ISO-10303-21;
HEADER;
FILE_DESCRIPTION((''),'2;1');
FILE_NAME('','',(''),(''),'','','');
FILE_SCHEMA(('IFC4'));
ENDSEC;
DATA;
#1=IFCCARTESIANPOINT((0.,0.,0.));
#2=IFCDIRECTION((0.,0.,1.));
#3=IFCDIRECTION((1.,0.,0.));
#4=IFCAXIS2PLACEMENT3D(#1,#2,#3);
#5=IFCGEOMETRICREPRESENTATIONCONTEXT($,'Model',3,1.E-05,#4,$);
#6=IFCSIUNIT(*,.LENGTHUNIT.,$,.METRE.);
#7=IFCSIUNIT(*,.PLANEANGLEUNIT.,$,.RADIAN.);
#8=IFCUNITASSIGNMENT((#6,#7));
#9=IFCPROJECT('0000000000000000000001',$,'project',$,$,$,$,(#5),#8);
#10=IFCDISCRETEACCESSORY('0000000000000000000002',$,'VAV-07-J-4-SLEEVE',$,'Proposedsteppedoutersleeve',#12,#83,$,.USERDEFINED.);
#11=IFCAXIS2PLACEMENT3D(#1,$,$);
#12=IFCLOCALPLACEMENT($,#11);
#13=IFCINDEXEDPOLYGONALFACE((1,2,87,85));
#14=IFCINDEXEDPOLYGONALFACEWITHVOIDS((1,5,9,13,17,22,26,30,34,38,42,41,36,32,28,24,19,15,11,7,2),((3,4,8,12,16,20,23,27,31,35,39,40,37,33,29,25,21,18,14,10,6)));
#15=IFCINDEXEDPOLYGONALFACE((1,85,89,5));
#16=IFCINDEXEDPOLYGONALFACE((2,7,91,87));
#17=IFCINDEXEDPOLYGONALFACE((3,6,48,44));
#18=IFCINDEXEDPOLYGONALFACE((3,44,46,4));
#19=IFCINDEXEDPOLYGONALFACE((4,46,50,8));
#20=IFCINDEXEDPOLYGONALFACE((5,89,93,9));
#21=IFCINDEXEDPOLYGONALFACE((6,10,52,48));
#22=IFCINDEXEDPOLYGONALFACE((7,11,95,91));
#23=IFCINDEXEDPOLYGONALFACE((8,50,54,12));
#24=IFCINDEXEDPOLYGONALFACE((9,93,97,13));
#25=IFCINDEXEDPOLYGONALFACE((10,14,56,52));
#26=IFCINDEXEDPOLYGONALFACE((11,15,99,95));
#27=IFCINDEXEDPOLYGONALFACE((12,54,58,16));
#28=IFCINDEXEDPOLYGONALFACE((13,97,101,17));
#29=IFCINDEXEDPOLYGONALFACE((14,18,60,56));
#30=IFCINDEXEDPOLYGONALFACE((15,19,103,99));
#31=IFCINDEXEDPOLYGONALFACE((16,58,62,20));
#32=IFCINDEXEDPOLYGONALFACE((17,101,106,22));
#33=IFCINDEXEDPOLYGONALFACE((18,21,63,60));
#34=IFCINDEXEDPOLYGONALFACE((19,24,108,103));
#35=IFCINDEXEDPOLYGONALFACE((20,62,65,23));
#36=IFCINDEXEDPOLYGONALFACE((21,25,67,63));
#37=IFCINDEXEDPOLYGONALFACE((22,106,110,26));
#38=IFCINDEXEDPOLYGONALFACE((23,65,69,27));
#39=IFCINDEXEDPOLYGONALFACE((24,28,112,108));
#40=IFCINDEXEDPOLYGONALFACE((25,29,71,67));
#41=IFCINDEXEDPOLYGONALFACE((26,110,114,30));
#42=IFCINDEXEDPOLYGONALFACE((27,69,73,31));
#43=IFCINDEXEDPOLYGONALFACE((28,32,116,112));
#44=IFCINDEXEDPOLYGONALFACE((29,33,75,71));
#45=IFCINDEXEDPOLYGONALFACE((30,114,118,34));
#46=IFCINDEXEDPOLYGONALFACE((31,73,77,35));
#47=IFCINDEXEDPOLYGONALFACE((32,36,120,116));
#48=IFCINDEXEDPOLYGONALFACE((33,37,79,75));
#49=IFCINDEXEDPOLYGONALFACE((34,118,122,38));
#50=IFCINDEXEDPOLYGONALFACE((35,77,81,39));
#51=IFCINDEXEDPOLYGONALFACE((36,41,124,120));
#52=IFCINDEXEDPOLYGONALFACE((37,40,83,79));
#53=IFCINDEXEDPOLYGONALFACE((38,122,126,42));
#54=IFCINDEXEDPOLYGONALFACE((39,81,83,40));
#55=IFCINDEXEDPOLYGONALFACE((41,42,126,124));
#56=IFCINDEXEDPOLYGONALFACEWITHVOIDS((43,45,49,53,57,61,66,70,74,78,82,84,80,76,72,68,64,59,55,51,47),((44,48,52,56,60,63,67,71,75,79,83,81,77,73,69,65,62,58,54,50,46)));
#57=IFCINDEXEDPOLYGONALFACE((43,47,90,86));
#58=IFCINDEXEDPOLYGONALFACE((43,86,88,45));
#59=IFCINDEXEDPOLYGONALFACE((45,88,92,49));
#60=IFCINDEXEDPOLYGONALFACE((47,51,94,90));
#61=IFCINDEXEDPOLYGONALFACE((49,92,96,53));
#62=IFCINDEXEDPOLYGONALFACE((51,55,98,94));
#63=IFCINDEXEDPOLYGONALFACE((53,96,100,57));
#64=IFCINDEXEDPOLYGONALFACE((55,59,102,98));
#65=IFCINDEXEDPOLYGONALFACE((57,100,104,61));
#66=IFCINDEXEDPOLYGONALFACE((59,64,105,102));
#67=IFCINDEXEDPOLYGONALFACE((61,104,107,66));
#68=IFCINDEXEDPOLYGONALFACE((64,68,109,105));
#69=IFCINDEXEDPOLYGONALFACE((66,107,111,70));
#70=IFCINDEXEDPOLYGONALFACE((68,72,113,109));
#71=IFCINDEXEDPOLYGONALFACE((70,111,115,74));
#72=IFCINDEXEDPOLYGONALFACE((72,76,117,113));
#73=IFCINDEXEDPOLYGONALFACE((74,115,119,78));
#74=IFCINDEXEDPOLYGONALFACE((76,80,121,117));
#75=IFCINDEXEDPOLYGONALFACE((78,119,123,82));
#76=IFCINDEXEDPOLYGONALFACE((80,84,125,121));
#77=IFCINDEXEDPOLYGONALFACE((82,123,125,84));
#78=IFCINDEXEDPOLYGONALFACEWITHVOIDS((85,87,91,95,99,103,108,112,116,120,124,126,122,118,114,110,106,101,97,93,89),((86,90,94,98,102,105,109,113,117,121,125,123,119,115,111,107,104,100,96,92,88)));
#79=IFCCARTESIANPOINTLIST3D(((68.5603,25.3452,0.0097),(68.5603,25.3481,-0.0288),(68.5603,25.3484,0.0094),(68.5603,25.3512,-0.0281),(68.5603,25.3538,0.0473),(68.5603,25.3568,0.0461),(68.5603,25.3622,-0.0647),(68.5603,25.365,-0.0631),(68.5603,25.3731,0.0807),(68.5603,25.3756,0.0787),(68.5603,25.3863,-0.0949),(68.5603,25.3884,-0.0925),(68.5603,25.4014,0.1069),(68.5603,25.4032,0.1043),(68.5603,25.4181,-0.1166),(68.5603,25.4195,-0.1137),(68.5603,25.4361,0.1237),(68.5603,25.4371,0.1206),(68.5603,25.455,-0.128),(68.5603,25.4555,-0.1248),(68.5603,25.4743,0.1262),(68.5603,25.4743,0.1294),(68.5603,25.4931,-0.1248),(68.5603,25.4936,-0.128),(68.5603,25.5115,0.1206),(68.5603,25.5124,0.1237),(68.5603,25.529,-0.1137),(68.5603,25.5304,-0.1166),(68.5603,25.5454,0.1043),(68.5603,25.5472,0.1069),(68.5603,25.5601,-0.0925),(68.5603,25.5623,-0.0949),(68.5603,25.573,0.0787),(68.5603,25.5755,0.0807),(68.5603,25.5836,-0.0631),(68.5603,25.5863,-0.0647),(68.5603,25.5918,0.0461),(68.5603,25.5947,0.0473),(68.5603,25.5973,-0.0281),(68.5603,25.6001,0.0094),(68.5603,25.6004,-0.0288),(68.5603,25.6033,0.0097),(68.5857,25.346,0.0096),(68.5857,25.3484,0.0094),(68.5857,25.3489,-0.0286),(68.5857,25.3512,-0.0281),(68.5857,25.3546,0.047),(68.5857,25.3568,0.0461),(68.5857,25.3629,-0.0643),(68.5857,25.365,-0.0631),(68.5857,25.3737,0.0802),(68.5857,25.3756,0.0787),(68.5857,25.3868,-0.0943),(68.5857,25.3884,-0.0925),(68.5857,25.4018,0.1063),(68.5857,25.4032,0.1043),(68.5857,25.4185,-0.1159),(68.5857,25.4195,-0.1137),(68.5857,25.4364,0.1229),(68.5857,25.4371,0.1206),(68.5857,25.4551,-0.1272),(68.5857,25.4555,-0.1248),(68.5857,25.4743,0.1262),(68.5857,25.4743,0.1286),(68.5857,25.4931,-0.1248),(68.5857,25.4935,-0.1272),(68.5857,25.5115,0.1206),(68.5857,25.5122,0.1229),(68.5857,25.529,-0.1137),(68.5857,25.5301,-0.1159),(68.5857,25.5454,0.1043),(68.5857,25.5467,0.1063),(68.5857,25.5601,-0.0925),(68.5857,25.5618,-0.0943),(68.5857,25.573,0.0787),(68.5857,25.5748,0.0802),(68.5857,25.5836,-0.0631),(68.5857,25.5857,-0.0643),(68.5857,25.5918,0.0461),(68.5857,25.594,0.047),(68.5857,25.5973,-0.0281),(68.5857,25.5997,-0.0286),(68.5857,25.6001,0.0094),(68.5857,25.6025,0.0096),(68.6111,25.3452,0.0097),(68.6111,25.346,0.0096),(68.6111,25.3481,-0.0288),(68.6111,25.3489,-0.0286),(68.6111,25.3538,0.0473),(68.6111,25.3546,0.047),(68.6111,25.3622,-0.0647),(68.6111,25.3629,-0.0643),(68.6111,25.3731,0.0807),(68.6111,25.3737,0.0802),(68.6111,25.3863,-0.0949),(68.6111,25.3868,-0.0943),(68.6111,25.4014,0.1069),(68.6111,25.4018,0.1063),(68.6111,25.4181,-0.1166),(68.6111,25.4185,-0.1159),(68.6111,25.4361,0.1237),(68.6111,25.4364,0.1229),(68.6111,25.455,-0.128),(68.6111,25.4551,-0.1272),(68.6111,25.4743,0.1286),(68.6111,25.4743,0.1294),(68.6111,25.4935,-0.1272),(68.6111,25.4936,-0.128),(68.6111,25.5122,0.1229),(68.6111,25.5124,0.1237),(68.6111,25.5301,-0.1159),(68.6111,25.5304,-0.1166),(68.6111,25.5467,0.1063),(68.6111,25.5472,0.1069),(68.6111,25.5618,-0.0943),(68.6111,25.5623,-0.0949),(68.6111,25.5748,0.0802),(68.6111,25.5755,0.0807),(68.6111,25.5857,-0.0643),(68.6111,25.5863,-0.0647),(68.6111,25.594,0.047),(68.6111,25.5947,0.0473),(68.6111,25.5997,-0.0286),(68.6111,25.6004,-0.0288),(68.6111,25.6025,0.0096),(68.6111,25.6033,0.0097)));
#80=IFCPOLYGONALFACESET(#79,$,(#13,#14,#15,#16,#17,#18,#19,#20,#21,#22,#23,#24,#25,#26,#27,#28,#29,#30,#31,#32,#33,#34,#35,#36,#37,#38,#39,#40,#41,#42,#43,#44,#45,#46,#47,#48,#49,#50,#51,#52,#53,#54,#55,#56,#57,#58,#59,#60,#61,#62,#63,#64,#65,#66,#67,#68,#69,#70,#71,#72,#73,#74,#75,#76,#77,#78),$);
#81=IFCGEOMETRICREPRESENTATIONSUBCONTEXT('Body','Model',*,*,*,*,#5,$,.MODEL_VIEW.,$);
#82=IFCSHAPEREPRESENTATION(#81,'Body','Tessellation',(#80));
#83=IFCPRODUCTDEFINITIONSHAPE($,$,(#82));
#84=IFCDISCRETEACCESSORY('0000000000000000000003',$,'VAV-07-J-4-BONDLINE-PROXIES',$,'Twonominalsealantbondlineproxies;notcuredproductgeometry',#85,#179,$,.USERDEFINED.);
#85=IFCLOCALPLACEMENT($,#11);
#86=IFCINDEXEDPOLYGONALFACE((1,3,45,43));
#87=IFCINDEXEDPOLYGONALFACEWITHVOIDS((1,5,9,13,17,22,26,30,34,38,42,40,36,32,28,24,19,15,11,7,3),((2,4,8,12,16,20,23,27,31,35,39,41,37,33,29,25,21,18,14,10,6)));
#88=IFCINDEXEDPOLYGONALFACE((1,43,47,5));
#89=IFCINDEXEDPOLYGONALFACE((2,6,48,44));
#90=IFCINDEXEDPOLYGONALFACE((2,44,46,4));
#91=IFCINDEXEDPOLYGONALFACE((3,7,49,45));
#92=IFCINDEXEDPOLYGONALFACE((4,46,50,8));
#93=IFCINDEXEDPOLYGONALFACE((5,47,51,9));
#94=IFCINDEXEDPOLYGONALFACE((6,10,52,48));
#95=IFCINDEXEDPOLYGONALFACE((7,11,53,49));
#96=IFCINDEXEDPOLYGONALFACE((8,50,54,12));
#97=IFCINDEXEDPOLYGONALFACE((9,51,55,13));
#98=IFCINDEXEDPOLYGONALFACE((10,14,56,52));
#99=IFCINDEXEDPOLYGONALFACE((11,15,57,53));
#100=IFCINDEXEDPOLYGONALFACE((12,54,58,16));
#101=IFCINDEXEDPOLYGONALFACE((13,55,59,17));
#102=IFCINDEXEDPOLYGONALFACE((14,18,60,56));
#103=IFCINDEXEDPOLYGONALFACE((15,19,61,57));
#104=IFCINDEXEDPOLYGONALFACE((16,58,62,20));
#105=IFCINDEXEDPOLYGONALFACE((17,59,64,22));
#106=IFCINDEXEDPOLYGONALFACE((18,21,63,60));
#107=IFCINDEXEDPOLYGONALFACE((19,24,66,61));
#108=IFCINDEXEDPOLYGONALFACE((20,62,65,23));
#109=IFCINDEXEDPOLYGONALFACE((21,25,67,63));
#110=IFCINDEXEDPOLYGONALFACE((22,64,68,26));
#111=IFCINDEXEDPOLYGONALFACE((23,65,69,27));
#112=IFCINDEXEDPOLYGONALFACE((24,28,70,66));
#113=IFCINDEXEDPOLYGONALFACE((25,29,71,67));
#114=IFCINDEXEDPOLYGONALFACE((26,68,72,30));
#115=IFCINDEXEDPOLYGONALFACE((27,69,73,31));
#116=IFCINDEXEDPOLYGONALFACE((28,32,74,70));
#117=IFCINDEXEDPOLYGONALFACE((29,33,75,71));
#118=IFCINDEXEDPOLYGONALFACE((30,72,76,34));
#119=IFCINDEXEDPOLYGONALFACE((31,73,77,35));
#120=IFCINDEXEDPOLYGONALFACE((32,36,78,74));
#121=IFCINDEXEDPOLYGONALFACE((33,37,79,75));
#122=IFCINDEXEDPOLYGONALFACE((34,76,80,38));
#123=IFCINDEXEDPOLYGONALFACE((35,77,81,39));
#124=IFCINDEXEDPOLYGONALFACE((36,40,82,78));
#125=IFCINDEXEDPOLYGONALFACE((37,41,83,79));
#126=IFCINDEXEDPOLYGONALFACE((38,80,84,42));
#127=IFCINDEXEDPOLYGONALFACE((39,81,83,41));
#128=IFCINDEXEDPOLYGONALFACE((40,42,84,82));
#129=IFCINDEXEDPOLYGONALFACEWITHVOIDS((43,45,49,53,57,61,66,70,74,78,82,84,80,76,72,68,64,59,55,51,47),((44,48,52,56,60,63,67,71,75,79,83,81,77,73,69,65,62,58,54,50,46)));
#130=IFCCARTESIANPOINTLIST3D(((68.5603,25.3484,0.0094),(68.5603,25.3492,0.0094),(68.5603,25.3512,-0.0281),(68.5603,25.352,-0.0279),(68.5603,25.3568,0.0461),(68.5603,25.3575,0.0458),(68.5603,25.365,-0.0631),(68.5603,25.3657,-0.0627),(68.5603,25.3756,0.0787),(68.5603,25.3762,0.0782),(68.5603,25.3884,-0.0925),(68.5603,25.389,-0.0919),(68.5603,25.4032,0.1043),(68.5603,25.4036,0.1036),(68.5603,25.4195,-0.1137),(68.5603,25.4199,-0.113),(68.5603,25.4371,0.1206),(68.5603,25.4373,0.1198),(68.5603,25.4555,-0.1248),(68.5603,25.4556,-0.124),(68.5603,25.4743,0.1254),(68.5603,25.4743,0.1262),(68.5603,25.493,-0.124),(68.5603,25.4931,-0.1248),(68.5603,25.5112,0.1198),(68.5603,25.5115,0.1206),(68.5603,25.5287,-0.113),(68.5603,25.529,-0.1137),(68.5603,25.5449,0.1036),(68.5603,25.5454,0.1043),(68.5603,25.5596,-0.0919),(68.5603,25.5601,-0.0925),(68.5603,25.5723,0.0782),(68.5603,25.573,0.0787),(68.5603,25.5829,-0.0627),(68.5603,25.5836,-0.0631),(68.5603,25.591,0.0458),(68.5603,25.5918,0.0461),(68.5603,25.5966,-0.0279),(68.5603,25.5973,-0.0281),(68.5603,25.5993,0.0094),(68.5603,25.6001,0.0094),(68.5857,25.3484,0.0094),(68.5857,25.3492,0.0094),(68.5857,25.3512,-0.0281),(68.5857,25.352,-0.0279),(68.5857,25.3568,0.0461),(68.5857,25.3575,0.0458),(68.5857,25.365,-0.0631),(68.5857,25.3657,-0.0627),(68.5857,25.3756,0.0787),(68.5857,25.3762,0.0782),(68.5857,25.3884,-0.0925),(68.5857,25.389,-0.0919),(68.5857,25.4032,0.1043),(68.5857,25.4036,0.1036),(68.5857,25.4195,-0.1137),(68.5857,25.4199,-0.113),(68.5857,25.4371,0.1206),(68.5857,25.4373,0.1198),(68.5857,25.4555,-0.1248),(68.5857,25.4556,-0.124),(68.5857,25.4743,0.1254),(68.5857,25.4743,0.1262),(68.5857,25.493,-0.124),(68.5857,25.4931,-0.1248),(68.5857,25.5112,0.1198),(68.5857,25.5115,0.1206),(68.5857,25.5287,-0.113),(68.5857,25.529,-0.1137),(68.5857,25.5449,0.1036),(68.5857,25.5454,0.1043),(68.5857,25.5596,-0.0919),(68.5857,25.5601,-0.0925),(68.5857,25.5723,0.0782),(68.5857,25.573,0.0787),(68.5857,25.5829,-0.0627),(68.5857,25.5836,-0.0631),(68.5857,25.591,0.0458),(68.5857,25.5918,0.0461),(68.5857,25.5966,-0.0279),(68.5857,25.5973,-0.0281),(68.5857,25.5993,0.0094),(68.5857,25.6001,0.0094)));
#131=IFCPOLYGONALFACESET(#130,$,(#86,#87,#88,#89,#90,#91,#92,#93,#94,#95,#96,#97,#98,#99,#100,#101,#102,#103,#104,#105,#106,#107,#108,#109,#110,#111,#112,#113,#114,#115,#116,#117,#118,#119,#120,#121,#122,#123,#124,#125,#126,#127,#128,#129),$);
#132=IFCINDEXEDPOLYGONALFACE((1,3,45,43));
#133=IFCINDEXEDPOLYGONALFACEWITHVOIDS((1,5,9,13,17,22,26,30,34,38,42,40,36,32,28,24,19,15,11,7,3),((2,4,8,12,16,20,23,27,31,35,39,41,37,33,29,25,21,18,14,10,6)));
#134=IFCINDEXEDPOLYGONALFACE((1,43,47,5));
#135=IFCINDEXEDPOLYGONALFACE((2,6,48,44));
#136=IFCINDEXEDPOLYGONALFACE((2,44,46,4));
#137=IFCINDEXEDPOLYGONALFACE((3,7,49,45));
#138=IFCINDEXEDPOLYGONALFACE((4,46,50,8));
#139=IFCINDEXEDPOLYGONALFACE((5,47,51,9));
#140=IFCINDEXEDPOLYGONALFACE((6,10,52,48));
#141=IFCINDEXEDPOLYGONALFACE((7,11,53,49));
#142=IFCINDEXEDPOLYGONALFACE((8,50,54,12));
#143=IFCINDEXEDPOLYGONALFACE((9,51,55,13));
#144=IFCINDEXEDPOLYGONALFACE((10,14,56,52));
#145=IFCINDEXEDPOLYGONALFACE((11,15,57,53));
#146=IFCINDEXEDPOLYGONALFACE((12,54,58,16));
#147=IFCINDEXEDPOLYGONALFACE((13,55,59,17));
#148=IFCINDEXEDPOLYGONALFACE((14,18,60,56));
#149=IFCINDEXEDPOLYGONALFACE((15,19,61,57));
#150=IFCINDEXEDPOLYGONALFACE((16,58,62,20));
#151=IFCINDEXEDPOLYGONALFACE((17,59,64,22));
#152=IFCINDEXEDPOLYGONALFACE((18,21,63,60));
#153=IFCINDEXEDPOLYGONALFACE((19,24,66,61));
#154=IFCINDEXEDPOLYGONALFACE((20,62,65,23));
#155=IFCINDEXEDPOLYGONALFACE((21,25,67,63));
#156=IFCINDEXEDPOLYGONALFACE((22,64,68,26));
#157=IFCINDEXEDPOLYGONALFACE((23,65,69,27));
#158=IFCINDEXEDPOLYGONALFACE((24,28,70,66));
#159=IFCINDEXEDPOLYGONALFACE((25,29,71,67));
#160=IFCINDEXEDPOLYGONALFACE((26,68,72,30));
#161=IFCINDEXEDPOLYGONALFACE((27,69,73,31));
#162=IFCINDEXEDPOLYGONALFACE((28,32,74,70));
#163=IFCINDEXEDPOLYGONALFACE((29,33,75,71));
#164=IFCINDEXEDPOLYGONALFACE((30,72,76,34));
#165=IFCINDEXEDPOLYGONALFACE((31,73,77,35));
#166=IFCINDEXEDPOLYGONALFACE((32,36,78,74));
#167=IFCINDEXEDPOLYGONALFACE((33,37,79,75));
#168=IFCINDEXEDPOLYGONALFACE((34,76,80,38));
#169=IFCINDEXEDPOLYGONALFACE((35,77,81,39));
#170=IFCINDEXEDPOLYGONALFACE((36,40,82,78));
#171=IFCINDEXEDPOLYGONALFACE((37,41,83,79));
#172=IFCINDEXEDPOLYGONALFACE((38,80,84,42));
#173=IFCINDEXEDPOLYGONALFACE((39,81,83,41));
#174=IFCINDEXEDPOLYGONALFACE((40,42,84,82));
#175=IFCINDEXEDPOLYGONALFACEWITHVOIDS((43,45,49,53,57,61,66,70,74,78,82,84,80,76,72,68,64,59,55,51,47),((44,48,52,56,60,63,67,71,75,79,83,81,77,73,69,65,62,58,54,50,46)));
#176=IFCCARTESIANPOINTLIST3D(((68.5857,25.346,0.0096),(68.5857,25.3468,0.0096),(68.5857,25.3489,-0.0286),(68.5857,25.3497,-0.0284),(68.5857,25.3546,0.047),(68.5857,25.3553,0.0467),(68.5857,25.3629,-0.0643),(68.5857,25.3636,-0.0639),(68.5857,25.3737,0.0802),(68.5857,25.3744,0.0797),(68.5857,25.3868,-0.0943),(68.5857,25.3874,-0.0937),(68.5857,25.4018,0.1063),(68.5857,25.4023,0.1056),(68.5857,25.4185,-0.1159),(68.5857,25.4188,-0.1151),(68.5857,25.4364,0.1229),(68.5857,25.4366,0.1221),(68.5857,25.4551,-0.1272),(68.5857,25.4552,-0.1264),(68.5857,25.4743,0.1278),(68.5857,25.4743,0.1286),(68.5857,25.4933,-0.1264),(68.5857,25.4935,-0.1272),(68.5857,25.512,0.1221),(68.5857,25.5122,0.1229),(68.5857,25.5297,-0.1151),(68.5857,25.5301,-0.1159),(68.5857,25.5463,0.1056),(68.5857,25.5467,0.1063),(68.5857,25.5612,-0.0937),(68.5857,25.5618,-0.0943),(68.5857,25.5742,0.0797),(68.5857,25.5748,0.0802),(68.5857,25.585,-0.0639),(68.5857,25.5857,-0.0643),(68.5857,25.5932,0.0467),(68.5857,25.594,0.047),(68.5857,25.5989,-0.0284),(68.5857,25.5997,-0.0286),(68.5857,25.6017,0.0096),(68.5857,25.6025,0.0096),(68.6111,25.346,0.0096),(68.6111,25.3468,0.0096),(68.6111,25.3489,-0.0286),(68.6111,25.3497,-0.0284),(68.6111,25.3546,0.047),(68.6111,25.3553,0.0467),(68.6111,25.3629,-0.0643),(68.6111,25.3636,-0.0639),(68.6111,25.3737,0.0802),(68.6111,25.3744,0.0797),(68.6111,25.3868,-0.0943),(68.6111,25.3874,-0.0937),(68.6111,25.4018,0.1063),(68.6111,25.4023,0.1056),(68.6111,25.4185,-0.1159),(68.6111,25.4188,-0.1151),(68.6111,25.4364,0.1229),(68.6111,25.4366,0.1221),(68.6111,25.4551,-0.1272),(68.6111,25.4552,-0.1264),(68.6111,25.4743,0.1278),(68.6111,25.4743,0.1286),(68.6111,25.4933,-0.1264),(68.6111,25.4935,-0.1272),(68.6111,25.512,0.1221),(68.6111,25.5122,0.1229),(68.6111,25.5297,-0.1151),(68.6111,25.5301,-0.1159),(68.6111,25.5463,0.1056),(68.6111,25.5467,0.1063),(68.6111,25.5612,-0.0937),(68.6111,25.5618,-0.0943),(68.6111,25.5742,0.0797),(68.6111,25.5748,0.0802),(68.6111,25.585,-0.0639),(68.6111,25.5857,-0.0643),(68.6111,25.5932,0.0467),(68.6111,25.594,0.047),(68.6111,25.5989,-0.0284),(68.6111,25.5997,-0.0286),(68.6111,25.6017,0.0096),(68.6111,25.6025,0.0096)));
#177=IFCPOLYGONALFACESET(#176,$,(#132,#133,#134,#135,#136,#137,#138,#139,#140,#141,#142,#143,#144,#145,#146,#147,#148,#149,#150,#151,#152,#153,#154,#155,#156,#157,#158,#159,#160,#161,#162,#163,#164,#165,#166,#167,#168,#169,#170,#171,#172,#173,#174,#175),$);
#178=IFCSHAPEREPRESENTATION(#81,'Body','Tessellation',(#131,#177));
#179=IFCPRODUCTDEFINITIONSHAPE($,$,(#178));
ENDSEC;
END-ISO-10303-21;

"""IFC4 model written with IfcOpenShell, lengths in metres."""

from ifc_helpers import new_model, entity, si_unit, frame, origin_with_axes, place, context, subcontext, project, element, save


model = new_model("IFC4")

# Units and contexts
model_context = context("Model", 3, precision=1e-05, world=origin_with_axes())
body_context = subcontext(model_context, "Body", "Model", "MODEL_VIEW")
ifc_project = project(units=[si_unit("LENGTHUNIT", "METRE"), si_unit("PLANEANGLEUNIT", "RADIAN")], contexts=[model_context])

# Discrete accessories
discrete_accessory_1_placement = place(None, frame((68.5857, 25.4743, 0.0), z_axis=(0.0, 1.0, 0.0), x_axis=(0.0, 0.0, 1.0)))
element("IfcDiscreteAccessory", 1, at=discrete_accessory_1_placement, Name="VAV-07-J-4-SLEEVE", ObjectType="Proposedsteppedoutersleeve", PredefinedType="USERDEFINED", context=body_context, shape_type="SweptSolid", body=[
    entity("IfcRevolvedAreaSolid", entity("IfcArbitraryClosedProfileDef", "AREA", None, entity("IfcPolyline", [entity("IfcCartesianPoint", [0.1262, -0.0254]), entity("IfcCartesianPoint", [0.1294, -0.0254]), entity("IfcCartesianPoint", [0.1294, 0.0254]), entity("IfcCartesianPoint", [0.1286, 0.0254]), entity("IfcCartesianPoint", [0.1286, 0.0]), entity("IfcCartesianPoint", [0.1262, 0.0]), entity("IfcCartesianPoint", [0.1262, -0.0254])])), entity("IfcAxis2Placement3D", entity("IfcCartesianPoint", [0.0, 0.0, 0.0])), entity("IfcAxis1Placement", entity("IfcCartesianPoint", [0.0, 0.0, 0.0]), entity("IfcDirection", [0.0, 1.0, 0.0])), 6.283185),
])
discrete_accessory_2_placement = place(None, frame((68.5857, 25.4743, 0.0), z_axis=(0.0, 1.0, 0.0), x_axis=(0.0, 0.0, 1.0)))
element("IfcDiscreteAccessory", 2, at=discrete_accessory_2_placement, Name="VAV-07-J-4-BONDLINE-PROXIES", ObjectType="Twonominalsealantbondlineproxies;notcuredproductgeometry", PredefinedType="USERDEFINED", context=body_context, shape_type="SweptSolid", body=[
    entity("IfcRevolvedAreaSolid", entity("IfcArbitraryClosedProfileDef", "AREA", None, entity("IfcPolyline", [entity("IfcCartesianPoint", [0.1254, -0.0254]), entity("IfcCartesianPoint", [0.1262, -0.0254]), entity("IfcCartesianPoint", [0.1262, 0.0]), entity("IfcCartesianPoint", [0.1254, 0.0]), entity("IfcCartesianPoint", [0.1254, -0.0254])])), entity("IfcAxis2Placement3D", entity("IfcCartesianPoint", [0.0, 0.0, 0.0])), entity("IfcAxis1Placement", entity("IfcCartesianPoint", [0.0, 0.0, 0.0]), entity("IfcDirection", [0.0, 1.0, 0.0])), 6.283185),
    entity("IfcRevolvedAreaSolid", entity("IfcArbitraryClosedProfileDef", "AREA", None, entity("IfcPolyline", [entity("IfcCartesianPoint", [0.1278, 0.0]), entity("IfcCartesianPoint", [0.1286, 0.0]), entity("IfcCartesianPoint", [0.1286, 0.0254]), entity("IfcCartesianPoint", [0.1278, 0.0254]), entity("IfcCartesianPoint", [0.1278, 0.0])])), entity("IfcAxis2Placement3D", entity("IfcCartesianPoint", [0.0, 0.0, 0.0])), entity("IfcAxis1Placement", entity("IfcCartesianPoint", [0.0, 0.0, 0.0]), entity("IfcDirection", [0.0, 1.0, 0.0])), 6.283185),
])

save(model, "model.ifc")
